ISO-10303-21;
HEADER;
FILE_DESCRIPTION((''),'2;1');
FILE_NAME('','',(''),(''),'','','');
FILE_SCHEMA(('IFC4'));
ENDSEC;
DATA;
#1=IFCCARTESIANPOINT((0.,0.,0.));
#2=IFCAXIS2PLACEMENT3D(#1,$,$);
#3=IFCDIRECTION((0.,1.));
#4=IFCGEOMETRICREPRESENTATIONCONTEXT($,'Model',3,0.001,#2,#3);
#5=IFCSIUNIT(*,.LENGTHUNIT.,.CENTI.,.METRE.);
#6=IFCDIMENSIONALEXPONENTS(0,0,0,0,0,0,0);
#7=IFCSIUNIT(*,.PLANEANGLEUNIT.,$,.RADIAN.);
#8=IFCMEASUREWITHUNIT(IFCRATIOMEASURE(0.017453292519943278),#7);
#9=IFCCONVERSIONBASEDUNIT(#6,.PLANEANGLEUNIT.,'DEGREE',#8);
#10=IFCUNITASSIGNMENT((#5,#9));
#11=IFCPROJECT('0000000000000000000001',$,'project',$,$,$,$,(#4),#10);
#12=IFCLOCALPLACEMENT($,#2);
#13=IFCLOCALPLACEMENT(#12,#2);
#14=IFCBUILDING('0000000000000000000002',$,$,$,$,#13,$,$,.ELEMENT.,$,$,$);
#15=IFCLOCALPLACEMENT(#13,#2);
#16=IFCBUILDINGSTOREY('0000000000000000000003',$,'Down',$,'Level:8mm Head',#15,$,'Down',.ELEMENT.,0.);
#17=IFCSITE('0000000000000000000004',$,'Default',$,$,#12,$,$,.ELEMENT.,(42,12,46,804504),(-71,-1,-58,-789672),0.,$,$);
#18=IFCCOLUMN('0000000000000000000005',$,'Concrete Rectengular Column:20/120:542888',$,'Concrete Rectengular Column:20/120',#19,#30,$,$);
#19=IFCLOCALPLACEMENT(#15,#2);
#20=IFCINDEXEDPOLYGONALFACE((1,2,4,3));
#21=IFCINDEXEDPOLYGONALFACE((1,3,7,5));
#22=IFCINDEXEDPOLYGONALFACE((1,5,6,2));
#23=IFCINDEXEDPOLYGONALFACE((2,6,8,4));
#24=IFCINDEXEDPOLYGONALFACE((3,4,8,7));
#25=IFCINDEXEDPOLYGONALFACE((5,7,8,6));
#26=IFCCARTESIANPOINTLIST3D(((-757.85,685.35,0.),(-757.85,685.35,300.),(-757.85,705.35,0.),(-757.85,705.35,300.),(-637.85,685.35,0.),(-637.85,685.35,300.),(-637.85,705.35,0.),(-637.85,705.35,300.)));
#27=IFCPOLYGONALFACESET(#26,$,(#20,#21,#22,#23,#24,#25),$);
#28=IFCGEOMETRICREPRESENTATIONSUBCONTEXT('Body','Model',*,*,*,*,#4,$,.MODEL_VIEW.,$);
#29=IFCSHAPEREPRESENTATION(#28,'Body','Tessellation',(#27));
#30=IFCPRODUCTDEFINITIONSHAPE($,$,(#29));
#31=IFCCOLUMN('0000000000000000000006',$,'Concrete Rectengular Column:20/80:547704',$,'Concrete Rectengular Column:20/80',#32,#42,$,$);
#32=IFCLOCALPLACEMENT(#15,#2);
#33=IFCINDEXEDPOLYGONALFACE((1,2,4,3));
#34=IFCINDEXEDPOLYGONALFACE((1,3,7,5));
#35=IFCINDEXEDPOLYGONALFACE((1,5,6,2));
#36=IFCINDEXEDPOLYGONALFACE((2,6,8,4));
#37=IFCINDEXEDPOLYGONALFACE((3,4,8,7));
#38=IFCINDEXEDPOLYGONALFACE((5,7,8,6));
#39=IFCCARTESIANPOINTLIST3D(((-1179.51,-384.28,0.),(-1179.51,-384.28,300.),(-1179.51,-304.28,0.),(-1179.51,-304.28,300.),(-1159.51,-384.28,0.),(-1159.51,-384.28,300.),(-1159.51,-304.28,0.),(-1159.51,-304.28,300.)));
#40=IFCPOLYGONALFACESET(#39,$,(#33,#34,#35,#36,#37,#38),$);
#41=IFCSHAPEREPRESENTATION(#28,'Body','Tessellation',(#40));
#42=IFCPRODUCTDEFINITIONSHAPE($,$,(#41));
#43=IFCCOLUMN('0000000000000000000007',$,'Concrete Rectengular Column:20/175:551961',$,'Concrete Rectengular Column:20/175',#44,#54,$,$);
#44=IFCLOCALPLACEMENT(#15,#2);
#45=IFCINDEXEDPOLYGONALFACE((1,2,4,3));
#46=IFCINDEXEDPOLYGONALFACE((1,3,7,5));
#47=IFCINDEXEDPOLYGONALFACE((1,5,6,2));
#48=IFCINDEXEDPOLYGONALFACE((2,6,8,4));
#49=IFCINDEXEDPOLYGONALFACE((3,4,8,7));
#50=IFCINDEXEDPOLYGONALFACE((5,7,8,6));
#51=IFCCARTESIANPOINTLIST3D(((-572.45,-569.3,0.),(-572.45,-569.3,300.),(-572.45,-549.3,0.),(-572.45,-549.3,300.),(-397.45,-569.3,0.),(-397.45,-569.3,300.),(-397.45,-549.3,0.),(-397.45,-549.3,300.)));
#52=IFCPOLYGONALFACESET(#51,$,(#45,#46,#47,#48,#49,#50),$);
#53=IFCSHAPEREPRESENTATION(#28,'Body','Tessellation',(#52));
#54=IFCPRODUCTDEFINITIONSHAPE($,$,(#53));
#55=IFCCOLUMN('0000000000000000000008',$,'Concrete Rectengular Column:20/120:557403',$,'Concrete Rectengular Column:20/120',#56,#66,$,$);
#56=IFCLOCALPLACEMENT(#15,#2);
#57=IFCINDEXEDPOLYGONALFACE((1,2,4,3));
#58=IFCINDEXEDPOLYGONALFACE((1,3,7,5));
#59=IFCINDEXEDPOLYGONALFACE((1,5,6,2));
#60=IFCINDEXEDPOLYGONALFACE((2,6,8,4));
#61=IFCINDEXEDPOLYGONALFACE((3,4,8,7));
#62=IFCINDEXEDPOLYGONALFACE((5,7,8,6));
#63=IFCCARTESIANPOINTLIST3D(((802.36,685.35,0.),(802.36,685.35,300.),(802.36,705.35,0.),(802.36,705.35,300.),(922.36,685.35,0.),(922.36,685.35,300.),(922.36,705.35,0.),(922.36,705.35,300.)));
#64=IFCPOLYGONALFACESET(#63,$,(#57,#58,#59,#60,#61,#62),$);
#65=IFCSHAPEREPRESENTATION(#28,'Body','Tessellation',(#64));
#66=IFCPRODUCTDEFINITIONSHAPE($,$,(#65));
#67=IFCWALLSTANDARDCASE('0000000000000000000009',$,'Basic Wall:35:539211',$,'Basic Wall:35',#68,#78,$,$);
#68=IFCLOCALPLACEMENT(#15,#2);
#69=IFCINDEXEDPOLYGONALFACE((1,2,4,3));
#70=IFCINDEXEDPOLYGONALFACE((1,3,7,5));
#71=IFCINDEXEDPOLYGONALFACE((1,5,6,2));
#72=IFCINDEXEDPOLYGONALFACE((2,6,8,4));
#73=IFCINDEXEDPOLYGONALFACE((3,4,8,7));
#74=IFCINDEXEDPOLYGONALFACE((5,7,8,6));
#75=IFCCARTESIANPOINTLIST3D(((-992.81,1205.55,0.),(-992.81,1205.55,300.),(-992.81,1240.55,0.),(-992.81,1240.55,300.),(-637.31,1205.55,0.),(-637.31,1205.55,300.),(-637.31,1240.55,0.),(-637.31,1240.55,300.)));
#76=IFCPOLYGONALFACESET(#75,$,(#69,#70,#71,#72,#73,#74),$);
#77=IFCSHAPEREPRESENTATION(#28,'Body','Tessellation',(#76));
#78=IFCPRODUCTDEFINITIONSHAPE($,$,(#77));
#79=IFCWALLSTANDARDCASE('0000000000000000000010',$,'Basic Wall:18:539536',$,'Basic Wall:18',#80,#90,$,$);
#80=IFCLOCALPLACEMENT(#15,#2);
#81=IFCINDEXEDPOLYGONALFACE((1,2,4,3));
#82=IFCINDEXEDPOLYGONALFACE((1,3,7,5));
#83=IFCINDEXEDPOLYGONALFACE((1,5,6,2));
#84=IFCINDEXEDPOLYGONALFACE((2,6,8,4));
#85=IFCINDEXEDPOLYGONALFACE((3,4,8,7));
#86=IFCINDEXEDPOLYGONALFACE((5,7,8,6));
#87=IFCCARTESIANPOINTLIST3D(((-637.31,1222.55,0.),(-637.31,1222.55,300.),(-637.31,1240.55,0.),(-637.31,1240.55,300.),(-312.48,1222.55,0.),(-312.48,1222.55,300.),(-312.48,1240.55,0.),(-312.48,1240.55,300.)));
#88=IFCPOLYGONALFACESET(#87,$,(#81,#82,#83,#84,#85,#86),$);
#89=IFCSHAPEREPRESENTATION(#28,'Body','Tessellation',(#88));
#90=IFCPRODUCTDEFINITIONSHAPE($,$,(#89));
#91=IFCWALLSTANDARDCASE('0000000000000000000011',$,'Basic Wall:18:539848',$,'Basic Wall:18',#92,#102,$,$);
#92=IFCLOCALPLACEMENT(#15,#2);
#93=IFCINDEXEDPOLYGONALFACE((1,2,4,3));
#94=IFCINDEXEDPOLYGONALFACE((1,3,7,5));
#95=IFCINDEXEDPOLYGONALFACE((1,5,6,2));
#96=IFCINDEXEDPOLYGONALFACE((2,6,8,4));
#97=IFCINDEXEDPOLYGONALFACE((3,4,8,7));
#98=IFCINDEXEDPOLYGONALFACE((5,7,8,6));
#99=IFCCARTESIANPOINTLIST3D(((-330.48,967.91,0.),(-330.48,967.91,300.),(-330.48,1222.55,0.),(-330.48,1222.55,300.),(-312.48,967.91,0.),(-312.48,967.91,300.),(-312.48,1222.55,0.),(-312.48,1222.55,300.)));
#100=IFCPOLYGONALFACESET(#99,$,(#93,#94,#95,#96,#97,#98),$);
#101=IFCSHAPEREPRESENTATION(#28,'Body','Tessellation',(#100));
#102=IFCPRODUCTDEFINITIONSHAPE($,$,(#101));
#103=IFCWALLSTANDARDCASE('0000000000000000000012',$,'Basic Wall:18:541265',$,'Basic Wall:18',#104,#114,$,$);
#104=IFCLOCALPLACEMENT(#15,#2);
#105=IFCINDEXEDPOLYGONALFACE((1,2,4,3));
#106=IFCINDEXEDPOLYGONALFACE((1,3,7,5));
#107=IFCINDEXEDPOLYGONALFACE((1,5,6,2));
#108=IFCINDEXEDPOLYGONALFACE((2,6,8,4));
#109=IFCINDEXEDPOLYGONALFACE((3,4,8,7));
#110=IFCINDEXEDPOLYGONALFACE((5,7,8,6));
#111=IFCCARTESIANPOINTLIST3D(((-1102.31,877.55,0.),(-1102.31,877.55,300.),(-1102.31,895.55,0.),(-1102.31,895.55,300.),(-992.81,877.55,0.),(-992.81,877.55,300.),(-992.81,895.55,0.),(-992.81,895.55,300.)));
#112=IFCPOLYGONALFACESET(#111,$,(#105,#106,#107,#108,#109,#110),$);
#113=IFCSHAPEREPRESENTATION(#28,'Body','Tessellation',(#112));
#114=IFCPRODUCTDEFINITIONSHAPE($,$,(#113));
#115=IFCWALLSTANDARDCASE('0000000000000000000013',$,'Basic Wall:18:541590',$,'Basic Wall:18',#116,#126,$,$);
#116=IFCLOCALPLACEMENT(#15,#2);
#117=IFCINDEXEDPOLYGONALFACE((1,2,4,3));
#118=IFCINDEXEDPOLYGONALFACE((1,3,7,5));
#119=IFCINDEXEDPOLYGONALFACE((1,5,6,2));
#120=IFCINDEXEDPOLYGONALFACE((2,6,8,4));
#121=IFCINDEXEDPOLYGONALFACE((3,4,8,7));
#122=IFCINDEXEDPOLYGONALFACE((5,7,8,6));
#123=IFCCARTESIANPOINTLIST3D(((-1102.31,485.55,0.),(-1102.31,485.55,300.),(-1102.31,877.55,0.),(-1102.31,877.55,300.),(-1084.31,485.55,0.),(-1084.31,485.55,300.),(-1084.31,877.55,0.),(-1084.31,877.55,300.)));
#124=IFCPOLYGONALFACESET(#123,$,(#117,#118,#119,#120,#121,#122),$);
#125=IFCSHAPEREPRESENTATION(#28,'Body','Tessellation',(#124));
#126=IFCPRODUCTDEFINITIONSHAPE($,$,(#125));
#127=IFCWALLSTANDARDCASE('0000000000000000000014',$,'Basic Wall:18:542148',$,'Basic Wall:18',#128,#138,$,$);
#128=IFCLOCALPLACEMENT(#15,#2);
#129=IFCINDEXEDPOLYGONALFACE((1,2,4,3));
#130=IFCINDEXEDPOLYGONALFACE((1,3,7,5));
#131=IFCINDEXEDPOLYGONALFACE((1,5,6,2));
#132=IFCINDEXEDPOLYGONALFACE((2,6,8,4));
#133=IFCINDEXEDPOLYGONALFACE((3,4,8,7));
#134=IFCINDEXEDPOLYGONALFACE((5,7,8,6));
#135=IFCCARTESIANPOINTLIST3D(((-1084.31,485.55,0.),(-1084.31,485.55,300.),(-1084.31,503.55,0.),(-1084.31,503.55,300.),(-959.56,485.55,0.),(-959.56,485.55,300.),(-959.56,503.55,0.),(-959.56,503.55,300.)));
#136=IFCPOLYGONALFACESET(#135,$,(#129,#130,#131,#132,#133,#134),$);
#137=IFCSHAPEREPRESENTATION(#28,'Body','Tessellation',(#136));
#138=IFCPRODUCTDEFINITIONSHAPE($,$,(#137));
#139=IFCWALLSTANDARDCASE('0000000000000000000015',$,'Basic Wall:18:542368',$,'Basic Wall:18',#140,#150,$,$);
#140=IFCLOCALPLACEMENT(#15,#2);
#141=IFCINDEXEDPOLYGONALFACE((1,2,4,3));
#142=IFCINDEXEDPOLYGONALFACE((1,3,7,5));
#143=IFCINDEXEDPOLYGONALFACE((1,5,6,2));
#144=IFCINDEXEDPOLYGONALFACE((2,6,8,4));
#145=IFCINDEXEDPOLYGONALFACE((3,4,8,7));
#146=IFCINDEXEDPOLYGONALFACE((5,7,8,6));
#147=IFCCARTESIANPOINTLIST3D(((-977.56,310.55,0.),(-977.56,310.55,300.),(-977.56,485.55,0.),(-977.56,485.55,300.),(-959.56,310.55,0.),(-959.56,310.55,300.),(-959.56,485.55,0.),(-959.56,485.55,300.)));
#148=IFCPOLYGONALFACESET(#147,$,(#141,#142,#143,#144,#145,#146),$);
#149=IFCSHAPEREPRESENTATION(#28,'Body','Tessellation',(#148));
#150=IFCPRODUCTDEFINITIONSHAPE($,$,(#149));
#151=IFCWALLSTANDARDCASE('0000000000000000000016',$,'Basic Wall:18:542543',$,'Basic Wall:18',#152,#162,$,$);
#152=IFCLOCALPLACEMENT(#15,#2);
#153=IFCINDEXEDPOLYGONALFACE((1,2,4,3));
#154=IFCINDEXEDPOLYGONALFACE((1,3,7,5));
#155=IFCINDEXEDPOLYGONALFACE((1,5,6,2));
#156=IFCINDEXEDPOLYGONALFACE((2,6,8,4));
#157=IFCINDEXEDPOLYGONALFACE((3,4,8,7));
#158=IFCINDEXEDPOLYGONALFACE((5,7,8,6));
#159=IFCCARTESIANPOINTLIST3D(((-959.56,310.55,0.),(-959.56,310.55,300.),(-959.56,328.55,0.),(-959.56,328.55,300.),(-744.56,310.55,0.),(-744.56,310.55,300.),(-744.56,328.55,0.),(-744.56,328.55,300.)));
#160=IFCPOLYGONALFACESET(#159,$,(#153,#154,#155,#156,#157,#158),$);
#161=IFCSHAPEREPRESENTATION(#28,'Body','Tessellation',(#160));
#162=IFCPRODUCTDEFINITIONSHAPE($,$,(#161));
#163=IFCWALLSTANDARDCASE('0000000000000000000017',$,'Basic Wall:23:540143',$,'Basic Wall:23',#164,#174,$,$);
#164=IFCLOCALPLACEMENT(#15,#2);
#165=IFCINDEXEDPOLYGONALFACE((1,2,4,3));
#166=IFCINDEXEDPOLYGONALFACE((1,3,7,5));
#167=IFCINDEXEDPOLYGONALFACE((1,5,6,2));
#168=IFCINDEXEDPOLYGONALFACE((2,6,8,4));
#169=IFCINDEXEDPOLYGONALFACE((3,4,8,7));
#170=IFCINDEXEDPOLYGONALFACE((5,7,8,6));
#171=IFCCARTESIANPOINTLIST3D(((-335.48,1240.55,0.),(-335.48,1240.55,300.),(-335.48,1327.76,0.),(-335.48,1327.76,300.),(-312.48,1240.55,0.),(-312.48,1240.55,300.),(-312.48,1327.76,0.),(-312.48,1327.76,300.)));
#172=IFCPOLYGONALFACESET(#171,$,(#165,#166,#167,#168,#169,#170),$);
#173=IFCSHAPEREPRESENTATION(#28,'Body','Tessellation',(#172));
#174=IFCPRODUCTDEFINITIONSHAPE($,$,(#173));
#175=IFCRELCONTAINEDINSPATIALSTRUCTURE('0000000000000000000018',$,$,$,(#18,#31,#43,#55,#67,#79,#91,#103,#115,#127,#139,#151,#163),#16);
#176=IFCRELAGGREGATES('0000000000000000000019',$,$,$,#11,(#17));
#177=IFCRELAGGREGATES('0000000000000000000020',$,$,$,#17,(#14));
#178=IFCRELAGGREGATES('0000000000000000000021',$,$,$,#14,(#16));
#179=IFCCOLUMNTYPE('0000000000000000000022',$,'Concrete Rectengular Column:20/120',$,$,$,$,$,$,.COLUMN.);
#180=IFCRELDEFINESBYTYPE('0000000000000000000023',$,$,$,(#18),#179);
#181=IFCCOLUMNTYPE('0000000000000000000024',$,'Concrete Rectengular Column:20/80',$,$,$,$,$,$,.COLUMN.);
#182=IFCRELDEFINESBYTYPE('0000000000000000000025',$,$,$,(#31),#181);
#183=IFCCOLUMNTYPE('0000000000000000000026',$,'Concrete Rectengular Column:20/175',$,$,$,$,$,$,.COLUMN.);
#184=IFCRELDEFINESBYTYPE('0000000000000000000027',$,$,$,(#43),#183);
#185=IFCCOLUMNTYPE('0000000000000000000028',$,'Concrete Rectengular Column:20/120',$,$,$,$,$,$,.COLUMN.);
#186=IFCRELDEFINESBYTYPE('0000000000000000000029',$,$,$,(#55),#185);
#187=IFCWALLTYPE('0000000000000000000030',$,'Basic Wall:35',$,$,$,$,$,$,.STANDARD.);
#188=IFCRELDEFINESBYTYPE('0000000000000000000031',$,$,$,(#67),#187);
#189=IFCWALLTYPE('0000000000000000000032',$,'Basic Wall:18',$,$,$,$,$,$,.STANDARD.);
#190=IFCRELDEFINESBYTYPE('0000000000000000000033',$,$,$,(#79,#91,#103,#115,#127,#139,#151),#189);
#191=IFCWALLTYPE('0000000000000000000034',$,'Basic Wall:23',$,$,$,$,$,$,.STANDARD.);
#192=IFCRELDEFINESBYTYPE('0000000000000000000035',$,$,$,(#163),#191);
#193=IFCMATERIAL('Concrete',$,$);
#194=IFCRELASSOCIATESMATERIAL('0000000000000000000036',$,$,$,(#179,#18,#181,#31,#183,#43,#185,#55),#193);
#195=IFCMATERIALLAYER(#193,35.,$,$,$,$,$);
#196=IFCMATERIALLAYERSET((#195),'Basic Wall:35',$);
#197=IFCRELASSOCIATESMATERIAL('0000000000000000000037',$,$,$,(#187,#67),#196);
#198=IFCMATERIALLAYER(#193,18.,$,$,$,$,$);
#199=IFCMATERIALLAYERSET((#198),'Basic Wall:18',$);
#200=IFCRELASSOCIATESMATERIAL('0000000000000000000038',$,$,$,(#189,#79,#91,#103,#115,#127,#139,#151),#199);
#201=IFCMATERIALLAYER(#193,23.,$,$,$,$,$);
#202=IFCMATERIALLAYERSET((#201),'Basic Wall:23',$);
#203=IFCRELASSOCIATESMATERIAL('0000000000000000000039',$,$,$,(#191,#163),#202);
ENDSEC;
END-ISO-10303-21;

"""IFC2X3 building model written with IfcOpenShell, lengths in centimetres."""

from ifc_helpers import new_model, entity, si_unit, converted_unit, direction, frame, frame_2d, origin, origin_2d_with_axis, place, context, subcontext, project, spatial, rectangle, extrude, source, transform, mapped, material, layer, layer_set, layer_usage, type_object, type_shapes, element, save


model = new_model("IFC2X3")

# Units and contexts
model_context = context("Model", 3, precision=0.001, world=origin(), true_north=direction((0.0, 1.0)))
body_context = subcontext(model_context, "Body", "Model", "MODEL_VIEW")
ifc_project = project(units=[si_unit("LENGTHUNIT", "METRE", prefix="CENTI"), converted_unit("PLANEANGLEUNIT", "DEGREE", entity("IfcRatioMeasure", 0.017453292519943278), si_unit("PLANEANGLEUNIT", "RADIAN"), dimensions=[0, 0, 0, 0, 0, 0, 0])], contexts=[model_context])

# Site, building, storey
site_placement = place(None, origin())
site = spatial("IfcSite", under=ifc_project, at=site_placement, Name="Default", CompositionType="ELEMENT", RefLatitude=(42, 12, 46, 804504), RefLongitude=(-71, -1, -58, -789672), RefElevation=0.0)
building_placement = place(site_placement, origin())
building = spatial("IfcBuilding", under=site, at=building_placement, CompositionType="ELEMENT")
storey_placement = place(building_placement, origin())
storey = spatial("IfcBuildingStorey", under=building, at=storey_placement, Name="Down", ObjectType="Level:8mm Head", LongName="Down", CompositionType="ELEMENT", Elevation=0.0)

# Columns
ifc_material = material(Name="Concrete")
column_type_1 = type_object("IfcColumnType", Name="Concrete Rectengular Column:20/120", PredefinedType="COLUMN", material=ifc_material)
shared_shape_1 = source(origin(), body_context, "Body", "SweptSolid", [
    extrude(rectangle(XDim=20.0, YDim=120.0, at=origin_2d_with_axis()), frame((-697.85, 695.35, 0.0), z_axis=(0.0, 0.0, 1.0), x_axis=(0.0, -1.0, 0.0)), (0.0, 0.0, 1.0), 300.0),
])
type_shapes(column_type_1, [shared_shape_1])
column_1_placement = place(storey_placement, origin())
element("IfcColumn", 1, at=column_1_placement, inside=storey, type_object=column_type_1, material=ifc_material, Name="Concrete Rectengular Column:20/120:542888", ObjectType="Concrete Rectengular Column:20/120", context=body_context, shape_type="MappedRepresentation", body=[
    mapped(shared_shape_1, transform((0.0, 0.0, 0.0), scale=1.0)),
])
column_type_2 = type_object("IfcColumnType", Name="Concrete Rectengular Column:20/80", PredefinedType="COLUMN", material=ifc_material)
shared_shape_2 = source(origin(), body_context, "Body", "SweptSolid", [
    extrude(rectangle(XDim=80.0, YDim=20.0, at=frame_2d((0.0, 0.0), x_axis=(1.0, 0.0))), frame((-1169.51, -344.28, 0.0), z_axis=(0.0, 0.0, 1.0), x_axis=(0.0, -1.0, 0.0)), (0.0, 0.0, 1.0), 300.0),
])
type_shapes(column_type_2, [shared_shape_2])
column_2_placement = place(storey_placement, origin())
element("IfcColumn", 2, at=column_2_placement, inside=storey, type_object=column_type_2, material=ifc_material, Name="Concrete Rectengular Column:20/80:547704", ObjectType="Concrete Rectengular Column:20/80", context=body_context, shape_type="MappedRepresentation", body=[
    mapped(shared_shape_2, transform((0.0, 0.0, 0.0), scale=1.0)),
])
column_type_3 = type_object("IfcColumnType", Name="Concrete Rectengular Column:20/175", PredefinedType="COLUMN", material=ifc_material)
shared_shape_3 = source(origin(), body_context, "Body", "SweptSolid", [
    extrude(rectangle(XDim=20.0, YDim=175.0, at=frame_2d((0.0, 0.0), x_axis=(1.0, 0.0))), frame((-484.95, -559.3, 0.0), z_axis=(0.0, 0.0, 1.0), x_axis=(0.0, -1.0, 0.0)), (0.0, 0.0, 1.0), 300.0),
])
type_shapes(column_type_3, [shared_shape_3])
column_3_placement = place(storey_placement, origin())
element("IfcColumn", 3, at=column_3_placement, inside=storey, type_object=column_type_3, material=ifc_material, Name="Concrete Rectengular Column:20/175:551961", ObjectType="Concrete Rectengular Column:20/175", context=body_context, shape_type="MappedRepresentation", body=[
    mapped(shared_shape_3, transform((0.0, 0.0, 0.0), scale=1.0)),
])
column_type_4 = type_object("IfcColumnType", Name="Concrete Rectengular Column:20/120", PredefinedType="COLUMN", material=ifc_material)
shared_shape_4 = source(origin(), body_context, "Body", "SweptSolid", [
    extrude(rectangle(XDim=20.0, YDim=120.0, at=origin_2d_with_axis()), frame((862.36, 695.35, 0.0), z_axis=(0.0, 0.0, 1.0), x_axis=(0.0, -1.0, 0.0)), (0.0, 0.0, 1.0), 300.0),
])
type_shapes(column_type_4, [shared_shape_4])
column_4_placement = place(storey_placement, origin())
element("IfcColumn", 4, at=column_4_placement, inside=storey, type_object=column_type_4, material=ifc_material, Name="Concrete Rectengular Column:20/120:557403", ObjectType="Concrete Rectengular Column:20/120", context=body_context, shape_type="MappedRepresentation", body=[
    mapped(shared_shape_4, transform((0.0, 0.0, 0.0), scale=1.0)),
])

# Walls
ifc_layer_1 = layer(ifc_material, 35.0)
ifc_layer_set_1 = layer_set([ifc_layer_1], Name="Basic Wall:35")
ifc_layer_usage_1 = layer_usage(ifc_layer_set_1, "AXIS2", "NEGATIVE", 17.5)
wall_type_1 = type_object("IfcWallType", Name="Basic Wall:35", PredefinedType="STANDARD", material=ifc_layer_set_1)
wall_1_placement = place(storey_placement, frame((-992.81, 1223.05, 0.0)))
element("IfcWallStandardCase", 5, at=wall_1_placement, inside=storey, type_object=wall_type_1, material=ifc_layer_usage_1, Name="Basic Wall:35:539211", ObjectType="Basic Wall:35", context=body_context, shape_type="SweptSolid", body=[
    extrude(rectangle(XDim=355.5, YDim=35.0, at=frame_2d((177.75, 0.0), x_axis=(-1.0, 0.0))), origin(), (0.0, 0.0, 1.0), 300.0),
])
ifc_layer_2 = layer(ifc_material, 18.0)
ifc_layer_set_2 = layer_set([ifc_layer_2], Name="Basic Wall:18")
ifc_layer_usage_2 = layer_usage(ifc_layer_set_2, "AXIS2", "NEGATIVE", 9.0)
wall_type_2 = type_object("IfcWallType", Name="Basic Wall:18", PredefinedType="STANDARD", material=ifc_layer_set_2)
wall_2_placement = place(storey_placement, frame((-637.31, 1231.55, 0.0)))
element("IfcWallStandardCase", 6, at=wall_2_placement, inside=storey, type_object=wall_type_2, material=ifc_layer_usage_2, Name="Basic Wall:18:539536", ObjectType="Basic Wall:18", context=body_context, shape_type="SweptSolid", body=[
    extrude(rectangle(XDim=324.84, YDim=18.0, at=frame_2d((162.42, 0.0), x_axis=(-1.0, 0.0))), origin(), (0.0, 0.0, 1.0), 300.0),
])
ifc_layer_usage_3 = layer_usage(ifc_layer_set_2, "AXIS2", "NEGATIVE", 9.0)
wall_3_placement = place(storey_placement, frame((-321.48, 1222.55, 0.0), z_axis=(0.0, 0.0, 1.0), x_axis=(0.0, -1.0, 0.0)))
element("IfcWallStandardCase", 7, at=wall_3_placement, inside=storey, type_object=wall_type_2, material=ifc_layer_usage_3, Name="Basic Wall:18:539848", ObjectType="Basic Wall:18", context=body_context, shape_type="SweptSolid", body=[
    extrude(rectangle(XDim=254.64, YDim=18.0, at=frame_2d((127.32, 0.0), x_axis=(-1.0, 0.0))), origin(), (0.0, 0.0, 1.0), 300.0),
])
ifc_layer_usage_4 = layer_usage(ifc_layer_set_2, "AXIS2", "NEGATIVE", 9.0)
wall_4_placement = place(storey_placement, frame((-992.81, 886.55, 0.0), z_axis=(0.0, 0.0, 1.0), x_axis=(-1.0, 0.0, 0.0)))
element("IfcWallStandardCase", 8, at=wall_4_placement, inside=storey, type_object=wall_type_2, material=ifc_layer_usage_4, Name="Basic Wall:18:541265", ObjectType="Basic Wall:18", context=body_context, shape_type="SweptSolid", body=[
    extrude(rectangle(XDim=109.5, YDim=18.0, at=frame_2d((54.75, 0.0), x_axis=(-1.0, 0.0))), origin(), (0.0, 0.0, 1.0), 300.0),
])
ifc_layer_usage_5 = layer_usage(ifc_layer_set_2, "AXIS2", "POSITIVE", -9.0)
wall_5_placement = place(storey_placement, frame((-1093.31, 877.55, 0.0), z_axis=(0.0, 0.0, 1.0), x_axis=(0.0, -1.0, 0.0)))
element("IfcWallStandardCase", 9, at=wall_5_placement, inside=storey, type_object=wall_type_2, material=ifc_layer_usage_5, Name="Basic Wall:18:541590", ObjectType="Basic Wall:18", context=body_context, shape_type="SweptSolid", body=[
    extrude(rectangle(XDim=392.0, YDim=18.0, at=frame_2d((196.0, 0.0), x_axis=(-1.0, 0.0))), origin(), (0.0, 0.0, 1.0), 300.0),
])
ifc_layer_usage_6 = layer_usage(ifc_layer_set_2, "AXIS2", "POSITIVE", -9.0)
wall_6_placement = place(storey_placement, frame((-1084.31, 494.55, 0.0)))
element("IfcWallStandardCase", 10, at=wall_6_placement, inside=storey, type_object=wall_type_2, material=ifc_layer_usage_6, Name="Basic Wall:18:542148", ObjectType="Basic Wall:18", context=body_context, shape_type="SweptSolid", body=[
    extrude(rectangle(XDim=124.75, YDim=18.0, at=frame_2d((62.38, 0.0), x_axis=(-1.0, 0.0))), origin(), (0.0, 0.0, 1.0), 300.0),
])
ifc_layer_usage_7 = layer_usage(ifc_layer_set_2, "AXIS2", "NEGATIVE", 9.0)
wall_7_placement = place(storey_placement, frame((-968.56, 485.55, 0.0), z_axis=(0.0, 0.0, 1.0), x_axis=(0.0, -1.0, 0.0)))
element("IfcWallStandardCase", 11, at=wall_7_placement, inside=storey, type_object=wall_type_2, material=ifc_layer_usage_7, Name="Basic Wall:18:542368", ObjectType="Basic Wall:18", context=body_context, shape_type="SweptSolid", body=[
    extrude(rectangle(XDim=175.0, YDim=18.0, at=frame_2d((87.5, 0.0), x_axis=(-1.0, 0.0))), origin(), (0.0, 0.0, 1.0), 300.0),
])
ifc_layer_usage_8 = layer_usage(ifc_layer_set_2, "AXIS2", "POSITIVE", -9.0)
wall_8_placement = place(storey_placement, frame((-959.56, 319.55, 0.0)))
element("IfcWallStandardCase", 12, at=wall_8_placement, inside=storey, type_object=wall_type_2, material=ifc_layer_usage_8, Name="Basic Wall:18:542543", ObjectType="Basic Wall:18", context=body_context, shape_type="SweptSolid", body=[
    extrude(rectangle(XDim=215.0, YDim=18.0, at=frame_2d((107.5, 0.0), x_axis=(-1.0, 0.0))), origin(), (0.0, 0.0, 1.0), 300.0),
])
ifc_layer_3 = layer(ifc_material, 23.0)
ifc_layer_set_3 = layer_set([ifc_layer_3], Name="Basic Wall:23")
ifc_layer_usage_9 = layer_usage(ifc_layer_set_3, "AXIS2", "POSITIVE", -11.5)
wall_type_3 = type_object("IfcWallType", Name="Basic Wall:23", PredefinedType="STANDARD", material=ifc_layer_set_3)
wall_9_placement = place(storey_placement, frame((-323.98, 1240.55, 0.0), z_axis=(0.0, 0.0, 1.0), x_axis=(0.0, 1.0, 0.0)))
element("IfcWallStandardCase", 13, at=wall_9_placement, inside=storey, type_object=wall_type_3, material=ifc_layer_usage_9, Name="Basic Wall:23:540143", ObjectType="Basic Wall:23", context=body_context, shape_type="SweptSolid", body=[
    extrude(rectangle(XDim=87.21, YDim=23.0, at=frame_2d((43.61, 0.0), x_axis=(-1.0, 0.0))), origin(), (0.0, 0.0, 1.0), 300.0),
])

save(model, "model.ifc")
